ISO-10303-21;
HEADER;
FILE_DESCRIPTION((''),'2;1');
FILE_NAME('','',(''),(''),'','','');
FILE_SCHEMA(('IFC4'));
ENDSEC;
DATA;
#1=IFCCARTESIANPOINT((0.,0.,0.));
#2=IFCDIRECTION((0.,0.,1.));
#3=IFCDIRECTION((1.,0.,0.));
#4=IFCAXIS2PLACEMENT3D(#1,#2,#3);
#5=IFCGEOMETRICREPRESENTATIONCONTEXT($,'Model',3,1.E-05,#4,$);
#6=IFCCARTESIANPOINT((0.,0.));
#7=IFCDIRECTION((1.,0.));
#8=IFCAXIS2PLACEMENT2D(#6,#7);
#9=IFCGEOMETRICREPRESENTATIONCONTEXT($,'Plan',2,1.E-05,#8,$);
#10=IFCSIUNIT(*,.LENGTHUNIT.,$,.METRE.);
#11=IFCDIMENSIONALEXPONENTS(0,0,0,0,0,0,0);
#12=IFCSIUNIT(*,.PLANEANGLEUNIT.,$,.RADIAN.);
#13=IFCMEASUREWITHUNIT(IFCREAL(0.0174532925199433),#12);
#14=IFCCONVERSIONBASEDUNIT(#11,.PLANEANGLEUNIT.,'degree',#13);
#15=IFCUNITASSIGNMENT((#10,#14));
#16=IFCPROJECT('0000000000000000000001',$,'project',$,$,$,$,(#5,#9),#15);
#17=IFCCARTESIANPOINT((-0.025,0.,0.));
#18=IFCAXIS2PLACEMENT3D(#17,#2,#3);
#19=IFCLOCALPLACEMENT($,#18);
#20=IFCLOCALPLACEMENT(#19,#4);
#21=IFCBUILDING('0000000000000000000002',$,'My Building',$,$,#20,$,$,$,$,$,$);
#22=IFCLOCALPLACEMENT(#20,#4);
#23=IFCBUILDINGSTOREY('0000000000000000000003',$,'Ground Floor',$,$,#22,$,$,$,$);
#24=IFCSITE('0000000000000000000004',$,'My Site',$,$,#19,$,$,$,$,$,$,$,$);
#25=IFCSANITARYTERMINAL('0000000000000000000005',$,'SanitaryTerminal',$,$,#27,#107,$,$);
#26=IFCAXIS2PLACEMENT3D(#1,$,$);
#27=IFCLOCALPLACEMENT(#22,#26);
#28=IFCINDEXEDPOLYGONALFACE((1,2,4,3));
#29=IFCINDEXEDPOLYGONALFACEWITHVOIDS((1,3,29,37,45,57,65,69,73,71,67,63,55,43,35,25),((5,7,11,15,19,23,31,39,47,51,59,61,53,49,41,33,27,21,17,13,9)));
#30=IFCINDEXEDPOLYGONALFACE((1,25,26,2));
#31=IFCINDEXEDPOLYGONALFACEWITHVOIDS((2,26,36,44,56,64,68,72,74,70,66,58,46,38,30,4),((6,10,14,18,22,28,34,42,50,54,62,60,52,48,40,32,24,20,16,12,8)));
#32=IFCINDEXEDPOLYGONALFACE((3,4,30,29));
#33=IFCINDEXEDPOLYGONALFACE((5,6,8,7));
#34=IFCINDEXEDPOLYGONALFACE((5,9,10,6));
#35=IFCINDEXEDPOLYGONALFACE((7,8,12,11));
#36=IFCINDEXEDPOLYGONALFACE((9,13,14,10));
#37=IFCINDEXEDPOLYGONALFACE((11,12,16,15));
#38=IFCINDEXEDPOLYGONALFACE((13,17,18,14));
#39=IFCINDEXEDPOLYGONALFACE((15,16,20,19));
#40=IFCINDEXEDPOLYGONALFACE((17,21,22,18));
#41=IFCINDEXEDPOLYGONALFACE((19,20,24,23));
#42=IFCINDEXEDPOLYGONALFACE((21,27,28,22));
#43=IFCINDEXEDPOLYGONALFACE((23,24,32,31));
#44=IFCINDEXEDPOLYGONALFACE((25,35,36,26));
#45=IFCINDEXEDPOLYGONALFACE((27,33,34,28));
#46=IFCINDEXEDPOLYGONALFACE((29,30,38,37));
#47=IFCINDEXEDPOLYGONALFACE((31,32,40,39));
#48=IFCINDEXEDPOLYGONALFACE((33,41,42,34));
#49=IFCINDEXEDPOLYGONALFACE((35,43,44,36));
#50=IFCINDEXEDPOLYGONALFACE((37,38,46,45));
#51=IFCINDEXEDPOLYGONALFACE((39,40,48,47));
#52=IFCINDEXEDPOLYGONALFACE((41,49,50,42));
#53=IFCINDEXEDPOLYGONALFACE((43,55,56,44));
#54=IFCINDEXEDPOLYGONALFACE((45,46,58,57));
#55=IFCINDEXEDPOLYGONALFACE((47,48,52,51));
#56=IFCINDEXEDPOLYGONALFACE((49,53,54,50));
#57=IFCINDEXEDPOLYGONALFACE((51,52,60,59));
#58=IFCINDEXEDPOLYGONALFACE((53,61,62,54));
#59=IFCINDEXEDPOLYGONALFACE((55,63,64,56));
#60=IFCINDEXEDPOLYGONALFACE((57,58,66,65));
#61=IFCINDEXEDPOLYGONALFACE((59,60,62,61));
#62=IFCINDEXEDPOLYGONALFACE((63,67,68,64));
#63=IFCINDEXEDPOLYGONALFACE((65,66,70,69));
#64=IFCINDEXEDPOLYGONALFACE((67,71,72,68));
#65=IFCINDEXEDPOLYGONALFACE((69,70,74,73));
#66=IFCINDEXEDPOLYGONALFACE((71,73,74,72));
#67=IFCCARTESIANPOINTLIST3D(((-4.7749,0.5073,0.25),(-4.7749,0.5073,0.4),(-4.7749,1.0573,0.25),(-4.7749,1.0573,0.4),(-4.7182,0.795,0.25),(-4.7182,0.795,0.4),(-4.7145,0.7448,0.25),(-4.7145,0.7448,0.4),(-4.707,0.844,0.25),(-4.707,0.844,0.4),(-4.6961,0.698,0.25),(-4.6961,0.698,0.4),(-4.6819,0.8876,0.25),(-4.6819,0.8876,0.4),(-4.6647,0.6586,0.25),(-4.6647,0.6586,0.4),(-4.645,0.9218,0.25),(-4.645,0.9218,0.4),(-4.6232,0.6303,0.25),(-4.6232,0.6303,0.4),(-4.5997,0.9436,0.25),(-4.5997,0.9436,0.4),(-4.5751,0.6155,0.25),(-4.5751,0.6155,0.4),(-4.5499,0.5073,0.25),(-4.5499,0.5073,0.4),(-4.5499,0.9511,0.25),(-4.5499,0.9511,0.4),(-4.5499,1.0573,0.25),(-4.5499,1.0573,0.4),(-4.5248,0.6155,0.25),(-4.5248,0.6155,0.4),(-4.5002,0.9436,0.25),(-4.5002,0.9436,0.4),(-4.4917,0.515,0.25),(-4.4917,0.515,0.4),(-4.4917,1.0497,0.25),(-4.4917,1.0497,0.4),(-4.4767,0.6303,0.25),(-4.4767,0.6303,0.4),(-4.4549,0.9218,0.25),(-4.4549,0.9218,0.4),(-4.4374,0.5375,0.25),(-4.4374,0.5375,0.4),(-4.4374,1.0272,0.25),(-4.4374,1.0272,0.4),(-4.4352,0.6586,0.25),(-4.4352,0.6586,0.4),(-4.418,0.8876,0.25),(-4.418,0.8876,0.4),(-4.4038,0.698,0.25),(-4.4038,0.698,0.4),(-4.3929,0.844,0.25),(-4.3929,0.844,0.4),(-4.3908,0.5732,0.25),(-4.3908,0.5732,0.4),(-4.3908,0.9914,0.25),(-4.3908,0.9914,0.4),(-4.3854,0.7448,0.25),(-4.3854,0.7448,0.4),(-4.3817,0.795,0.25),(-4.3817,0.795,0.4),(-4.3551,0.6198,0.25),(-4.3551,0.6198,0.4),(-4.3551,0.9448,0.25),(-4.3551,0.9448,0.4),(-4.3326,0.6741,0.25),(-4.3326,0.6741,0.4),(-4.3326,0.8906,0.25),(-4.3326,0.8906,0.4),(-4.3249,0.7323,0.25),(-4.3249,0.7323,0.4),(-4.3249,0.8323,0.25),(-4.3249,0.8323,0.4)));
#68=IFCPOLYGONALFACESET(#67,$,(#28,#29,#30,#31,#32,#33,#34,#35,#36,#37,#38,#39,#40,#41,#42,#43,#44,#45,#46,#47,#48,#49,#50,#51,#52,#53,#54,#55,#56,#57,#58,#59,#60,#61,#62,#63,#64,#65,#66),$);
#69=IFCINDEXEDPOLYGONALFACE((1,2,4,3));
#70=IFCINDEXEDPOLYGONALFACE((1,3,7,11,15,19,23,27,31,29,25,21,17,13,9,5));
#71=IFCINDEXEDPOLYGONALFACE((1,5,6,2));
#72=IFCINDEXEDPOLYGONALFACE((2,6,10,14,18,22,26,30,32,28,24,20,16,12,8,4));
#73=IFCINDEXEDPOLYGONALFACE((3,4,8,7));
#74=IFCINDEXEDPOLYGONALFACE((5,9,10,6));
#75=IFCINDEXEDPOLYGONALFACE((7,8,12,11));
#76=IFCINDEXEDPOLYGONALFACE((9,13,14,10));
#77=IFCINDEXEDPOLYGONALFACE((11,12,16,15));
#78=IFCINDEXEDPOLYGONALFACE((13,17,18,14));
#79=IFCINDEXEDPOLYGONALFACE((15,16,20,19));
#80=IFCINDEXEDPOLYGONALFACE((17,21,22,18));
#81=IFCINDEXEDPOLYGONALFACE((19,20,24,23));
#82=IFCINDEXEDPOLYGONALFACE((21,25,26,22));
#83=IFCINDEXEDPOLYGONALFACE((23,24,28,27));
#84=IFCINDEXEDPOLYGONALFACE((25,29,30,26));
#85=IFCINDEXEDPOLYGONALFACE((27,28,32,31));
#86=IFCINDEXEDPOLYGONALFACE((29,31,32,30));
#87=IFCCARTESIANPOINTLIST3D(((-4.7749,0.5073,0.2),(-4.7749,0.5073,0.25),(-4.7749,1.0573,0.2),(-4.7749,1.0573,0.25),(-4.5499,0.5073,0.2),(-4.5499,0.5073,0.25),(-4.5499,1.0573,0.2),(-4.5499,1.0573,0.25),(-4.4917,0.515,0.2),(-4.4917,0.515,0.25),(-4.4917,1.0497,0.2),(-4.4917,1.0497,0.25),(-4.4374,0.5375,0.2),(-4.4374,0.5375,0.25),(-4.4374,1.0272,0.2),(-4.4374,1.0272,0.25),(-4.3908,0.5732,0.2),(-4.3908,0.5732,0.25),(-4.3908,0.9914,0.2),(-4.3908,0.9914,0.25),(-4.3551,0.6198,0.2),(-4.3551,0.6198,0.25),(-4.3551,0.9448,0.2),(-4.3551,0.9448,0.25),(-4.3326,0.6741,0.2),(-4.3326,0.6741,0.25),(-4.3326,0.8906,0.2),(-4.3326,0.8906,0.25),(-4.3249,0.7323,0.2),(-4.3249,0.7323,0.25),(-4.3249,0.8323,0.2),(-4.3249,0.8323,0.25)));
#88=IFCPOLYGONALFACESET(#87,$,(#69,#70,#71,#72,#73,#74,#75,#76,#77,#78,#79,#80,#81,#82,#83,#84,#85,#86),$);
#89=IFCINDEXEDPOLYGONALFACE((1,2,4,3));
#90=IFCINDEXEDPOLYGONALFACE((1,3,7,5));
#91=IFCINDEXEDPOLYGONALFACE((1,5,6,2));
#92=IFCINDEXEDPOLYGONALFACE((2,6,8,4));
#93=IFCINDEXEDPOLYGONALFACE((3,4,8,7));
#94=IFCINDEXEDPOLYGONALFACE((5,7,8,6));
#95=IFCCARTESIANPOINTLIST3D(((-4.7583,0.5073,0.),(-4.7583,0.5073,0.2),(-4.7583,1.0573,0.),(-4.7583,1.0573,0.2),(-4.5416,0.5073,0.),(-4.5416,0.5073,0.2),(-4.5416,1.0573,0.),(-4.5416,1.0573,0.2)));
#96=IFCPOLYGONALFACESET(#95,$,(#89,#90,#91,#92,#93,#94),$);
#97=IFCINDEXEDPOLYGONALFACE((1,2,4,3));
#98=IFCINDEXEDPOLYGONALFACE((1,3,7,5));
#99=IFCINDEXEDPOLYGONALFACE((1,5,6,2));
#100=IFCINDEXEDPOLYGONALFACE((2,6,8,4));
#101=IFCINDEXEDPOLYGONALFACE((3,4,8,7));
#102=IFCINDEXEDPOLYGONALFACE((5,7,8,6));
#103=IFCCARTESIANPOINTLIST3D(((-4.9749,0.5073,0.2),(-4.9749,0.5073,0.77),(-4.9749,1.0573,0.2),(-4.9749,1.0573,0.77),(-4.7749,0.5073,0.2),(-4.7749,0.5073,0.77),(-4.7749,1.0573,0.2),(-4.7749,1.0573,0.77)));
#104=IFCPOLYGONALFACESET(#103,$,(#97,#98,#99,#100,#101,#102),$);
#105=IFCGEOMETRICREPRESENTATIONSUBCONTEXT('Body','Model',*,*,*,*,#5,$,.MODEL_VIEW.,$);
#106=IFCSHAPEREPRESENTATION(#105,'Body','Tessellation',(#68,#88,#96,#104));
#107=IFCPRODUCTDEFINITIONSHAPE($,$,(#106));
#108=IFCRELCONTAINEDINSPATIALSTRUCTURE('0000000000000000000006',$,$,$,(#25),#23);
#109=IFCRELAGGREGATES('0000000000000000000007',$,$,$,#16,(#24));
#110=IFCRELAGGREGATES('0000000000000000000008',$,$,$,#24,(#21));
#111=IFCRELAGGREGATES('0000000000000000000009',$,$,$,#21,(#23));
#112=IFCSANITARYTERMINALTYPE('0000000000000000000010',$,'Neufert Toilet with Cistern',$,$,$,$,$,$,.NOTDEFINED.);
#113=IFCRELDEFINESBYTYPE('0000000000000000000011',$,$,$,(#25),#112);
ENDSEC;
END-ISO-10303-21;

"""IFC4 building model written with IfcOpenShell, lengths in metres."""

from ifc_helpers import new_model, entity, si_unit, converted_unit, frame, frame_2d, origin_with_axes, origin_2d_with_axis, place, context, subcontext, project, spatial, line, arc, indexed_curve, circle_curve, outline, extrude, shape, source, transform, mapped, type_object, type_shapes, element, save


model = new_model("IFC4")

# Units and contexts
model_context = context("Model", 3, precision=1e-05, world=origin_with_axes())
plan_context = context("Plan", 2, precision=1e-05, world=origin_2d_with_axis())
body_context_1 = subcontext(model_context, "Body", "Model", "MODEL_VIEW")
body_context_2 = subcontext(plan_context, "Body", "Plan", "PLAN_VIEW")
ifc_project = project(units=[si_unit("LENGTHUNIT", "METRE"), converted_unit("PLANEANGLEUNIT", "degree", entity("IfcReal", 0.0174532925199433), si_unit("PLANEANGLEUNIT", "RADIAN"), dimensions=[0, 0, 0, 0, 0, 0, 0])], contexts=[model_context, plan_context])

# Site, building, storey
site_placement = place(None, frame((-0.025, 0.0, 0.0), z_axis=(0.0, 0.0, 1.0), x_axis=(1.0, 0.0, 0.0)))
site = spatial("IfcSite", under=ifc_project, at=site_placement, Name="My Site")
building_placement = place(site_placement, origin_with_axes())
building = spatial("IfcBuilding", under=site, at=building_placement, Name="My Building")
storey_placement = place(building_placement, frame((0.0, 0.0, 0.0), z_axis=(0.0, 0.0, 1.0), x_axis=(1.0, 0.0, 0.0)))
storey = spatial("IfcBuildingStorey", under=building, at=storey_placement, Name="Ground Floor")

# Sanitary terminal
sanitary_terminal_type_1 = type_object("IfcSanitaryTerminalType", Name="Neufert Toilet with Cistern", PredefinedType="NOTDEFINED")
shared_shape_1 = source(origin_with_axes(), body_context_1, "Body", "SweptSolid", [
    extrude(outline(indexed_curve([(-0.275, -0.2), (0.275, -0.2), (0.275, -0.425), (0.2091, -0.5841), (0.05, -0.65), (-0.05, -0.65), (-0.2091, -0.5841), (-0.275, -0.425)], segments=[line(1, 2), line(2, 3), arc(3, 4, 5), line(5, 6), arc(6, 7, 8), line(8, 1)]), holes=[circle_curve(frame_2d((0.0, -0.425)), 0.1688)]), frame((0.0, 0.0, 0.25), z_axis=(0.0, 0.0, 1.0), x_axis=(1.0, 0.0, 0.0)), (0.0, 0.0, 1.0), 0.15),
    extrude(outline(indexed_curve([(-0.275, -0.2), (0.275, -0.2), (0.275, -0.425), (0.2091, -0.5841), (0.05, -0.65), (-0.05, -0.65), (-0.2091, -0.5841), (-0.275, -0.425)], segments=[line(1, 2), line(2, 3), arc(3, 4, 5), line(5, 6), arc(6, 7, 8), line(8, 1)])), frame((0.0, 0.0, 0.2), z_axis=(0.0, 0.0, 1.0), x_axis=(1.0, 0.0, 0.0)), (0.0, 0.0, 1.0), 0.05),
    extrude(outline(indexed_curve([(-0.275, -0.2167), (0.275, -0.2167), (0.275, -0.4333), (-0.275, -0.4333)], segments=[line(1, 2, 3, 4, 1)])), origin_with_axes(), (0.0, 0.0, 1.0), 0.2),
    extrude(outline(indexed_curve([(-0.275, 0.0), (0.275, 0.0), (0.275, -0.2), (-0.275, -0.2)], segments=[line(1, 2, 3, 4, 1)])), frame((0.0, 0.0, 0.2), z_axis=(0.0, 0.0, 1.0), x_axis=(1.0, 0.0, 0.0)), (0.0, 0.0, 1.0), 0.57),
])
shared_shape_2 = source(origin_with_axes(), body_context_2, "Body", "Curve2D", [
    entity("IfcIndexedPolyCurve", entity("IfcCartesianPointList2D", [[-0.275, 0.0], [0.275, 0.0], [0.275, -0.2], [-0.275, -0.2]]), [entity("IfcLineIndex", [1, 2, 3, 4, 1])]),
    entity("IfcIndexedPolyCurve", entity("IfcCartesianPointList2D", [[0.165, -0.2], [0.1925, -0.335]])),
    entity("IfcTrimmedCurve", entity("IfcEllipse", entity("IfcAxis2Placement2D", entity("IfcCartesianPoint", [0.0, -0.335]), entity("IfcDirection", [1.0, 0.0])), 0.1925, 0.315), [entity("IfcCartesianPoint", [-0.1925, -0.335])], [entity("IfcCartesianPoint", [0.1925, -0.335])], True, "CARTESIAN"),
    entity("IfcIndexedPolyCurve", entity("IfcCartesianPointList2D", [[-0.165, -0.2], [-0.1925, -0.335]])),
    entity("IfcEllipse", entity("IfcAxis2Placement2D", entity("IfcCartesianPoint", [0.0, -0.452]), entity("IfcDirection", [1.0, 0.0])), 0.1313, 0.1575),
    entity("IfcIndexedPolyCurve", entity("IfcCartesianPointList2D", [[-0.0344, -0.452], [-0.0344, -0.4295], [0.0344, -0.4295], [0.0344, -0.452]])),
    entity("IfcTrimmedCurve", entity("IfcEllipse", entity("IfcAxis2Placement2D", entity("IfcCartesianPoint", [0.0, -0.452]), entity("IfcDirection", [1.0, 0.0])), 0.0344, 0.0225), [entity("IfcCartesianPoint", [-0.0344, -0.452])], [entity("IfcCartesianPoint", [0.0344, -0.452])], True, "CARTESIAN"),
])
type_shapes(sanitary_terminal_type_1, [shared_shape_1, shared_shape_2])
sanitary_terminal_1_placement = place(storey_placement, frame((-4.9749, 0.7823, 0.0), z_axis=(0.0, 0.0, 1.0), x_axis=(0.0, 1.0, 0.0)))
element("IfcSanitaryTerminal", 1, at=sanitary_terminal_1_placement, inside=storey, type_object=sanitary_terminal_type_1, Name="SanitaryTerminal", shapes=[
    shape(body_context_1, "Body", "MappedRepresentation", [mapped(shared_shape_1, transform((0.0, 0.0, 0.0), x_axis=(1.0, 0.0, 0.0), y_axis=(0.0, 1.0, 0.0), z_axis=(0.0, 0.0, 1.0), scale=1.0))]),
    shape(body_context_2, "Body", "MappedRepresentation", [mapped(shared_shape_2, transform((0.0, 0.0, 0.0), x_axis=(1.0, 0.0, 0.0), y_axis=(0.0, 1.0, 0.0), z_axis=(0.0, 0.0, 1.0), scale=1.0))]),
])

save(model, "model.ifc")
